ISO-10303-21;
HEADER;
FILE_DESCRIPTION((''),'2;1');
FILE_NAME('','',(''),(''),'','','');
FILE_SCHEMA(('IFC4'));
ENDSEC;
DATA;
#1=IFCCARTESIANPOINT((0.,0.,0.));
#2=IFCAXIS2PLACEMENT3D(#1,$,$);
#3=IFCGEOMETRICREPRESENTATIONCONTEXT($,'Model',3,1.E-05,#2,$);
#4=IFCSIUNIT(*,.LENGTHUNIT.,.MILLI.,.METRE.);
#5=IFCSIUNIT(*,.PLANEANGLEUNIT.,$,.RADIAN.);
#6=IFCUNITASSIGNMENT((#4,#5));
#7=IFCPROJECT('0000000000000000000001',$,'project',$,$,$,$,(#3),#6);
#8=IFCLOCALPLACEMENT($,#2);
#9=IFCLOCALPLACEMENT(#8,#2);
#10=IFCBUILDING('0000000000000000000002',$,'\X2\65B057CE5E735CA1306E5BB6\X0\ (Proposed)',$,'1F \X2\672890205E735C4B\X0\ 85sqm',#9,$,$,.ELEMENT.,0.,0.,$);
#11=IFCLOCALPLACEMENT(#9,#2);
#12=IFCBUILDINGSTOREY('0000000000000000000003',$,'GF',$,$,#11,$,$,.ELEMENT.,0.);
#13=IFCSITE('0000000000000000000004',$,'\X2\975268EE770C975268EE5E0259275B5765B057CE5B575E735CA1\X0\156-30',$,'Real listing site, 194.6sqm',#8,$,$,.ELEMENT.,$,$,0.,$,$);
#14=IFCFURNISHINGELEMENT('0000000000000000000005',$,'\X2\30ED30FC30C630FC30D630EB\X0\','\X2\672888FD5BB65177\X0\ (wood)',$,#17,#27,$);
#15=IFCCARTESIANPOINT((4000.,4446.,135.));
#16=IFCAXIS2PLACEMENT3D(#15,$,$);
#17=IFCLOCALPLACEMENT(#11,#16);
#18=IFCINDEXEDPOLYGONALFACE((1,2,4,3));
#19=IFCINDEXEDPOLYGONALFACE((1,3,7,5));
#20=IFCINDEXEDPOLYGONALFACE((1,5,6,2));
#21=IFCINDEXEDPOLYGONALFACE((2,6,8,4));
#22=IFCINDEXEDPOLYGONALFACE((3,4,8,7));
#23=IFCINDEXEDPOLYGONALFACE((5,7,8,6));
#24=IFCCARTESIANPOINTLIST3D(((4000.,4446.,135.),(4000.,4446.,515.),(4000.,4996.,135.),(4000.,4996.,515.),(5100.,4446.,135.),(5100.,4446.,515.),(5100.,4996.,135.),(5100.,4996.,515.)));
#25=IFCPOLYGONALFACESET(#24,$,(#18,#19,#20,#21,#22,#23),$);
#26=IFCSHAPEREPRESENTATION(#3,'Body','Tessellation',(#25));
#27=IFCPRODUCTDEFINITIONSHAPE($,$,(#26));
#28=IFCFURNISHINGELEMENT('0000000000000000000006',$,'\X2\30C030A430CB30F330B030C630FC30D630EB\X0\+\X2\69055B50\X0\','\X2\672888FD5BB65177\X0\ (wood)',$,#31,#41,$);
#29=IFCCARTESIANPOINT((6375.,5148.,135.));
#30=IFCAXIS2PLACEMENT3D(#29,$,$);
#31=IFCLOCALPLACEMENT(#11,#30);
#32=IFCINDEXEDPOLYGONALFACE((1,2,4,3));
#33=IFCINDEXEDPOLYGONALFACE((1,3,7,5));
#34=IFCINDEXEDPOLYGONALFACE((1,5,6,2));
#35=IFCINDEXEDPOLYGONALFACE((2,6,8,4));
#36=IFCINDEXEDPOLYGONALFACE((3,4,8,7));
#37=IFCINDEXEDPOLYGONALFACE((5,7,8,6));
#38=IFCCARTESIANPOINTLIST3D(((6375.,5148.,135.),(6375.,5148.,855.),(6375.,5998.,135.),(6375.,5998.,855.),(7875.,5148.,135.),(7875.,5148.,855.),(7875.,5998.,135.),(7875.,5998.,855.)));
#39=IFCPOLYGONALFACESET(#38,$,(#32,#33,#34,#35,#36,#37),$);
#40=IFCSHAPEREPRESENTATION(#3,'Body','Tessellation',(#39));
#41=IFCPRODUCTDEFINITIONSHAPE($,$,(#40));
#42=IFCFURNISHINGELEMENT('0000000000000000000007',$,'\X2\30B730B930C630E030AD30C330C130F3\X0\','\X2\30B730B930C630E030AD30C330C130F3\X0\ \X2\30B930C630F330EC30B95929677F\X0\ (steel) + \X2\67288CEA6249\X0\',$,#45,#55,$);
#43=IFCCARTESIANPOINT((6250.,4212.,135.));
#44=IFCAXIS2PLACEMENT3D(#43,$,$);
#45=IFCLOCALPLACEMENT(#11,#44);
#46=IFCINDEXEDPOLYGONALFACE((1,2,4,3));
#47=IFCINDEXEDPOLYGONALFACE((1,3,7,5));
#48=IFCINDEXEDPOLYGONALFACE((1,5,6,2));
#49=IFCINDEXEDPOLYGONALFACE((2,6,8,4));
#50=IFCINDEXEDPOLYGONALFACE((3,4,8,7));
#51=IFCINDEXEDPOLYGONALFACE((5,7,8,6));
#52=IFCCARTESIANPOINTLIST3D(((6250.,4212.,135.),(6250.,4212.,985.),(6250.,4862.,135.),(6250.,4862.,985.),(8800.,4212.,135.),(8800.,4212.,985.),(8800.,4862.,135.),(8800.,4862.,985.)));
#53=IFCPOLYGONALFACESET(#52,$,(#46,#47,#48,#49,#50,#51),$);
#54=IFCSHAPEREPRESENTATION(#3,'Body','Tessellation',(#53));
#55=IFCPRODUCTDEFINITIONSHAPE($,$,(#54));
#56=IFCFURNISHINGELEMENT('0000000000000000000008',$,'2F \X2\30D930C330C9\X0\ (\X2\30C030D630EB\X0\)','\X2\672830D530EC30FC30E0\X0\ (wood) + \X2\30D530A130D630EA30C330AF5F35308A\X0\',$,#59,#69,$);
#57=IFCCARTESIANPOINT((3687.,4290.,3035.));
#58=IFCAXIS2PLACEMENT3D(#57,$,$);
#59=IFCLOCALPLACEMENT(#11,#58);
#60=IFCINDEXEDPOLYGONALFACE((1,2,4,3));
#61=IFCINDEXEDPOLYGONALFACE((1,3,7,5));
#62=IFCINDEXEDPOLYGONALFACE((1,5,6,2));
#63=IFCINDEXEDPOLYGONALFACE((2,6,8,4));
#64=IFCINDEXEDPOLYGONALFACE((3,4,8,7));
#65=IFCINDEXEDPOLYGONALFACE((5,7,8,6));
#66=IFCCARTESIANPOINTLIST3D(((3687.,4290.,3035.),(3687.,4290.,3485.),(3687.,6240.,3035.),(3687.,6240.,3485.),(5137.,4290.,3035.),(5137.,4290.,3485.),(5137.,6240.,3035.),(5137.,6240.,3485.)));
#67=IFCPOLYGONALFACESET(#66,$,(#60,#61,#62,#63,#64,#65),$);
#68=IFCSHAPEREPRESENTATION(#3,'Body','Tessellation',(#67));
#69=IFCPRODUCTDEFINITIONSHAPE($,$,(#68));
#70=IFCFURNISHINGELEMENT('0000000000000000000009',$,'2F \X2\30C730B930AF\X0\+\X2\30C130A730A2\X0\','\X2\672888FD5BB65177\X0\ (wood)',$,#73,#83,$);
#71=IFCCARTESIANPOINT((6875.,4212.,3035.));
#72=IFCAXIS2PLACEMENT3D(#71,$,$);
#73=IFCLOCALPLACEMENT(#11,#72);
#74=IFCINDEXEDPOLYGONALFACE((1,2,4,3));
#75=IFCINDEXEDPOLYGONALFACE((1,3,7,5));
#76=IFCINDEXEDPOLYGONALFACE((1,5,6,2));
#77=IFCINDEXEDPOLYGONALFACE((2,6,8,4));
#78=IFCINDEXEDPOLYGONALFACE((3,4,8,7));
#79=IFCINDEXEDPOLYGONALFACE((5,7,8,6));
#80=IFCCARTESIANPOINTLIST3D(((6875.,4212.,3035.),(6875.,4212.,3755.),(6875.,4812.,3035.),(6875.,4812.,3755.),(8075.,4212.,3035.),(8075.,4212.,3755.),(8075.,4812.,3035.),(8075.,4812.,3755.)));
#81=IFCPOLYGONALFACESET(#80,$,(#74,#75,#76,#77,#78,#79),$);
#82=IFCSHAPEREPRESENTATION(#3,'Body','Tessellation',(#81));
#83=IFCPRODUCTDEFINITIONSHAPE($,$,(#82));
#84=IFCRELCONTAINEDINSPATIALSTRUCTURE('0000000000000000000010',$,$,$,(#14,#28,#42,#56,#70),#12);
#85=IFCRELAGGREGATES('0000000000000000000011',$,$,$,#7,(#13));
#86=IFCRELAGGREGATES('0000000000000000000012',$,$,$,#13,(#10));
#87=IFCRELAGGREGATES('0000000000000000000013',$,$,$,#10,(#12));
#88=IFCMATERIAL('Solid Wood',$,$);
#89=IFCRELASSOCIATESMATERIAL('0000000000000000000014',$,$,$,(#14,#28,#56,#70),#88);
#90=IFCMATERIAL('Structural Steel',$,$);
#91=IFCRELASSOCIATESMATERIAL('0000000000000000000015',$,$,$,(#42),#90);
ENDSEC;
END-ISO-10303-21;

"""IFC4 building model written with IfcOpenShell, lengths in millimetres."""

from ifc_helpers import new_model, si_unit, frame, frame_2d, origin, place, context, project, spatial, rectangle, extrude, material, element, save


model = new_model("IFC4")

# Units and contexts
model_context = context("Model", 3, precision=1e-05, world=origin())
ifc_project = project(units=[si_unit("LENGTHUNIT", "METRE", prefix="MILLI"), si_unit("PLANEANGLEUNIT", "RADIAN")], contexts=[model_context])

# Site, building, storey
site_placement = place(None, origin())
site = spatial("IfcSite", under=ifc_project, at=site_placement, Name="青森県青森市大字新城字平岡156-30", ObjectType="Real listing site, 194.6sqm", CompositionType="ELEMENT", RefElevation=0.0)
building_placement = place(site_placement, origin())
building = spatial("IfcBuilding", under=site, at=building_placement, Name="新城平岡の家 (Proposed)", ObjectType="1F 木造平屋 85sqm", CompositionType="ELEMENT", ElevationOfRefHeight=0.0, ElevationOfTerrain=0.0)
storey_placement = place(building_placement, origin())
storey = spatial("IfcBuildingStorey", under=building, at=storey_placement, Name="GF", CompositionType="ELEMENT", Elevation=0.0)

# Shared definitions
ifc_material_1 = material(Name="Solid Wood")

# Shared definitions
ifc_material_2 = material(Name="Structural Steel")

# Furnishing elements
furnishing_1_placement = place(storey_placement, frame((4000.0, 4446.0, 135.0)))
element("IfcFurnishingElement", 1, at=furnishing_1_placement, inside=storey, material=ifc_material_1, Name="ローテーブル", Description="木製家具 (wood)", context=model_context, shape_type="SweptSolid", body=[
    extrude(rectangle(XDim=1100.0, YDim=550.0, at=frame_2d((550.0, 275.0))), frame((4000.0, 4446.0, 135.0)), (0.0, 0.0, 1.0), 380.0),
])
furnishing_2_placement = place(storey_placement, frame((6375.0, 5148.0, 135.0)))
element("IfcFurnishingElement", 2, at=furnishing_2_placement, inside=storey, material=ifc_material_1, Name="ダイニングテーブル+椅子", Description="木製家具 (wood)", context=model_context, shape_type="SweptSolid", body=[
    extrude(rectangle(XDim=1500.0, YDim=850.0, at=frame_2d((750.0, 425.0))), frame((6375.0, 5148.0, 135.0)), (0.0, 0.0, 1.0), 720.0),
])
furnishing_3_placement = place(storey_placement, frame((6250.0, 4212.0, 135.0)))
element("IfcFurnishingElement", 3, at=furnishing_3_placement, inside=storey, material=ifc_material_2, Name="システムキッチン", Description="システムキッチン ステンレス天板 (steel) + 木質扉", context=model_context, shape_type="SweptSolid", body=[
    extrude(rectangle(XDim=2550.0, YDim=650.0, at=frame_2d((1275.0, 325.0))), frame((6250.0, 4212.0, 135.0)), (0.0, 0.0, 1.0), 850.0),
])
furnishing_4_placement = place(storey_placement, frame((3687.0, 4290.0, 3035.0)))
element("IfcFurnishingElement", 4, at=furnishing_4_placement, inside=storey, material=ifc_material_1, Name="2F ベッド (ダブル)", Description="木フレーム (wood) + ファブリック張り", context=model_context, shape_type="SweptSolid", body=[
    extrude(rectangle(XDim=1450.0, YDim=1950.0, at=frame_2d((725.0, 975.0))), frame((3687.0, 4290.0, 3035.0)), (0.0, 0.0, 1.0), 450.0),
])
furnishing_5_placement = place(storey_placement, frame((6875.0, 4212.0, 3035.0)))
element("IfcFurnishingElement", 5, at=furnishing_5_placement, inside=storey, material=ifc_material_1, Name="2F デスク+チェア", Description="木製家具 (wood)", context=model_context, shape_type="SweptSolid", body=[
    extrude(rectangle(XDim=1200.0, YDim=600.0, at=frame_2d((600.0, 300.0))), frame((6875.0, 4212.0, 3035.0)), (0.0, 0.0, 1.0), 720.0),
])

save(model, "model.ifc")
